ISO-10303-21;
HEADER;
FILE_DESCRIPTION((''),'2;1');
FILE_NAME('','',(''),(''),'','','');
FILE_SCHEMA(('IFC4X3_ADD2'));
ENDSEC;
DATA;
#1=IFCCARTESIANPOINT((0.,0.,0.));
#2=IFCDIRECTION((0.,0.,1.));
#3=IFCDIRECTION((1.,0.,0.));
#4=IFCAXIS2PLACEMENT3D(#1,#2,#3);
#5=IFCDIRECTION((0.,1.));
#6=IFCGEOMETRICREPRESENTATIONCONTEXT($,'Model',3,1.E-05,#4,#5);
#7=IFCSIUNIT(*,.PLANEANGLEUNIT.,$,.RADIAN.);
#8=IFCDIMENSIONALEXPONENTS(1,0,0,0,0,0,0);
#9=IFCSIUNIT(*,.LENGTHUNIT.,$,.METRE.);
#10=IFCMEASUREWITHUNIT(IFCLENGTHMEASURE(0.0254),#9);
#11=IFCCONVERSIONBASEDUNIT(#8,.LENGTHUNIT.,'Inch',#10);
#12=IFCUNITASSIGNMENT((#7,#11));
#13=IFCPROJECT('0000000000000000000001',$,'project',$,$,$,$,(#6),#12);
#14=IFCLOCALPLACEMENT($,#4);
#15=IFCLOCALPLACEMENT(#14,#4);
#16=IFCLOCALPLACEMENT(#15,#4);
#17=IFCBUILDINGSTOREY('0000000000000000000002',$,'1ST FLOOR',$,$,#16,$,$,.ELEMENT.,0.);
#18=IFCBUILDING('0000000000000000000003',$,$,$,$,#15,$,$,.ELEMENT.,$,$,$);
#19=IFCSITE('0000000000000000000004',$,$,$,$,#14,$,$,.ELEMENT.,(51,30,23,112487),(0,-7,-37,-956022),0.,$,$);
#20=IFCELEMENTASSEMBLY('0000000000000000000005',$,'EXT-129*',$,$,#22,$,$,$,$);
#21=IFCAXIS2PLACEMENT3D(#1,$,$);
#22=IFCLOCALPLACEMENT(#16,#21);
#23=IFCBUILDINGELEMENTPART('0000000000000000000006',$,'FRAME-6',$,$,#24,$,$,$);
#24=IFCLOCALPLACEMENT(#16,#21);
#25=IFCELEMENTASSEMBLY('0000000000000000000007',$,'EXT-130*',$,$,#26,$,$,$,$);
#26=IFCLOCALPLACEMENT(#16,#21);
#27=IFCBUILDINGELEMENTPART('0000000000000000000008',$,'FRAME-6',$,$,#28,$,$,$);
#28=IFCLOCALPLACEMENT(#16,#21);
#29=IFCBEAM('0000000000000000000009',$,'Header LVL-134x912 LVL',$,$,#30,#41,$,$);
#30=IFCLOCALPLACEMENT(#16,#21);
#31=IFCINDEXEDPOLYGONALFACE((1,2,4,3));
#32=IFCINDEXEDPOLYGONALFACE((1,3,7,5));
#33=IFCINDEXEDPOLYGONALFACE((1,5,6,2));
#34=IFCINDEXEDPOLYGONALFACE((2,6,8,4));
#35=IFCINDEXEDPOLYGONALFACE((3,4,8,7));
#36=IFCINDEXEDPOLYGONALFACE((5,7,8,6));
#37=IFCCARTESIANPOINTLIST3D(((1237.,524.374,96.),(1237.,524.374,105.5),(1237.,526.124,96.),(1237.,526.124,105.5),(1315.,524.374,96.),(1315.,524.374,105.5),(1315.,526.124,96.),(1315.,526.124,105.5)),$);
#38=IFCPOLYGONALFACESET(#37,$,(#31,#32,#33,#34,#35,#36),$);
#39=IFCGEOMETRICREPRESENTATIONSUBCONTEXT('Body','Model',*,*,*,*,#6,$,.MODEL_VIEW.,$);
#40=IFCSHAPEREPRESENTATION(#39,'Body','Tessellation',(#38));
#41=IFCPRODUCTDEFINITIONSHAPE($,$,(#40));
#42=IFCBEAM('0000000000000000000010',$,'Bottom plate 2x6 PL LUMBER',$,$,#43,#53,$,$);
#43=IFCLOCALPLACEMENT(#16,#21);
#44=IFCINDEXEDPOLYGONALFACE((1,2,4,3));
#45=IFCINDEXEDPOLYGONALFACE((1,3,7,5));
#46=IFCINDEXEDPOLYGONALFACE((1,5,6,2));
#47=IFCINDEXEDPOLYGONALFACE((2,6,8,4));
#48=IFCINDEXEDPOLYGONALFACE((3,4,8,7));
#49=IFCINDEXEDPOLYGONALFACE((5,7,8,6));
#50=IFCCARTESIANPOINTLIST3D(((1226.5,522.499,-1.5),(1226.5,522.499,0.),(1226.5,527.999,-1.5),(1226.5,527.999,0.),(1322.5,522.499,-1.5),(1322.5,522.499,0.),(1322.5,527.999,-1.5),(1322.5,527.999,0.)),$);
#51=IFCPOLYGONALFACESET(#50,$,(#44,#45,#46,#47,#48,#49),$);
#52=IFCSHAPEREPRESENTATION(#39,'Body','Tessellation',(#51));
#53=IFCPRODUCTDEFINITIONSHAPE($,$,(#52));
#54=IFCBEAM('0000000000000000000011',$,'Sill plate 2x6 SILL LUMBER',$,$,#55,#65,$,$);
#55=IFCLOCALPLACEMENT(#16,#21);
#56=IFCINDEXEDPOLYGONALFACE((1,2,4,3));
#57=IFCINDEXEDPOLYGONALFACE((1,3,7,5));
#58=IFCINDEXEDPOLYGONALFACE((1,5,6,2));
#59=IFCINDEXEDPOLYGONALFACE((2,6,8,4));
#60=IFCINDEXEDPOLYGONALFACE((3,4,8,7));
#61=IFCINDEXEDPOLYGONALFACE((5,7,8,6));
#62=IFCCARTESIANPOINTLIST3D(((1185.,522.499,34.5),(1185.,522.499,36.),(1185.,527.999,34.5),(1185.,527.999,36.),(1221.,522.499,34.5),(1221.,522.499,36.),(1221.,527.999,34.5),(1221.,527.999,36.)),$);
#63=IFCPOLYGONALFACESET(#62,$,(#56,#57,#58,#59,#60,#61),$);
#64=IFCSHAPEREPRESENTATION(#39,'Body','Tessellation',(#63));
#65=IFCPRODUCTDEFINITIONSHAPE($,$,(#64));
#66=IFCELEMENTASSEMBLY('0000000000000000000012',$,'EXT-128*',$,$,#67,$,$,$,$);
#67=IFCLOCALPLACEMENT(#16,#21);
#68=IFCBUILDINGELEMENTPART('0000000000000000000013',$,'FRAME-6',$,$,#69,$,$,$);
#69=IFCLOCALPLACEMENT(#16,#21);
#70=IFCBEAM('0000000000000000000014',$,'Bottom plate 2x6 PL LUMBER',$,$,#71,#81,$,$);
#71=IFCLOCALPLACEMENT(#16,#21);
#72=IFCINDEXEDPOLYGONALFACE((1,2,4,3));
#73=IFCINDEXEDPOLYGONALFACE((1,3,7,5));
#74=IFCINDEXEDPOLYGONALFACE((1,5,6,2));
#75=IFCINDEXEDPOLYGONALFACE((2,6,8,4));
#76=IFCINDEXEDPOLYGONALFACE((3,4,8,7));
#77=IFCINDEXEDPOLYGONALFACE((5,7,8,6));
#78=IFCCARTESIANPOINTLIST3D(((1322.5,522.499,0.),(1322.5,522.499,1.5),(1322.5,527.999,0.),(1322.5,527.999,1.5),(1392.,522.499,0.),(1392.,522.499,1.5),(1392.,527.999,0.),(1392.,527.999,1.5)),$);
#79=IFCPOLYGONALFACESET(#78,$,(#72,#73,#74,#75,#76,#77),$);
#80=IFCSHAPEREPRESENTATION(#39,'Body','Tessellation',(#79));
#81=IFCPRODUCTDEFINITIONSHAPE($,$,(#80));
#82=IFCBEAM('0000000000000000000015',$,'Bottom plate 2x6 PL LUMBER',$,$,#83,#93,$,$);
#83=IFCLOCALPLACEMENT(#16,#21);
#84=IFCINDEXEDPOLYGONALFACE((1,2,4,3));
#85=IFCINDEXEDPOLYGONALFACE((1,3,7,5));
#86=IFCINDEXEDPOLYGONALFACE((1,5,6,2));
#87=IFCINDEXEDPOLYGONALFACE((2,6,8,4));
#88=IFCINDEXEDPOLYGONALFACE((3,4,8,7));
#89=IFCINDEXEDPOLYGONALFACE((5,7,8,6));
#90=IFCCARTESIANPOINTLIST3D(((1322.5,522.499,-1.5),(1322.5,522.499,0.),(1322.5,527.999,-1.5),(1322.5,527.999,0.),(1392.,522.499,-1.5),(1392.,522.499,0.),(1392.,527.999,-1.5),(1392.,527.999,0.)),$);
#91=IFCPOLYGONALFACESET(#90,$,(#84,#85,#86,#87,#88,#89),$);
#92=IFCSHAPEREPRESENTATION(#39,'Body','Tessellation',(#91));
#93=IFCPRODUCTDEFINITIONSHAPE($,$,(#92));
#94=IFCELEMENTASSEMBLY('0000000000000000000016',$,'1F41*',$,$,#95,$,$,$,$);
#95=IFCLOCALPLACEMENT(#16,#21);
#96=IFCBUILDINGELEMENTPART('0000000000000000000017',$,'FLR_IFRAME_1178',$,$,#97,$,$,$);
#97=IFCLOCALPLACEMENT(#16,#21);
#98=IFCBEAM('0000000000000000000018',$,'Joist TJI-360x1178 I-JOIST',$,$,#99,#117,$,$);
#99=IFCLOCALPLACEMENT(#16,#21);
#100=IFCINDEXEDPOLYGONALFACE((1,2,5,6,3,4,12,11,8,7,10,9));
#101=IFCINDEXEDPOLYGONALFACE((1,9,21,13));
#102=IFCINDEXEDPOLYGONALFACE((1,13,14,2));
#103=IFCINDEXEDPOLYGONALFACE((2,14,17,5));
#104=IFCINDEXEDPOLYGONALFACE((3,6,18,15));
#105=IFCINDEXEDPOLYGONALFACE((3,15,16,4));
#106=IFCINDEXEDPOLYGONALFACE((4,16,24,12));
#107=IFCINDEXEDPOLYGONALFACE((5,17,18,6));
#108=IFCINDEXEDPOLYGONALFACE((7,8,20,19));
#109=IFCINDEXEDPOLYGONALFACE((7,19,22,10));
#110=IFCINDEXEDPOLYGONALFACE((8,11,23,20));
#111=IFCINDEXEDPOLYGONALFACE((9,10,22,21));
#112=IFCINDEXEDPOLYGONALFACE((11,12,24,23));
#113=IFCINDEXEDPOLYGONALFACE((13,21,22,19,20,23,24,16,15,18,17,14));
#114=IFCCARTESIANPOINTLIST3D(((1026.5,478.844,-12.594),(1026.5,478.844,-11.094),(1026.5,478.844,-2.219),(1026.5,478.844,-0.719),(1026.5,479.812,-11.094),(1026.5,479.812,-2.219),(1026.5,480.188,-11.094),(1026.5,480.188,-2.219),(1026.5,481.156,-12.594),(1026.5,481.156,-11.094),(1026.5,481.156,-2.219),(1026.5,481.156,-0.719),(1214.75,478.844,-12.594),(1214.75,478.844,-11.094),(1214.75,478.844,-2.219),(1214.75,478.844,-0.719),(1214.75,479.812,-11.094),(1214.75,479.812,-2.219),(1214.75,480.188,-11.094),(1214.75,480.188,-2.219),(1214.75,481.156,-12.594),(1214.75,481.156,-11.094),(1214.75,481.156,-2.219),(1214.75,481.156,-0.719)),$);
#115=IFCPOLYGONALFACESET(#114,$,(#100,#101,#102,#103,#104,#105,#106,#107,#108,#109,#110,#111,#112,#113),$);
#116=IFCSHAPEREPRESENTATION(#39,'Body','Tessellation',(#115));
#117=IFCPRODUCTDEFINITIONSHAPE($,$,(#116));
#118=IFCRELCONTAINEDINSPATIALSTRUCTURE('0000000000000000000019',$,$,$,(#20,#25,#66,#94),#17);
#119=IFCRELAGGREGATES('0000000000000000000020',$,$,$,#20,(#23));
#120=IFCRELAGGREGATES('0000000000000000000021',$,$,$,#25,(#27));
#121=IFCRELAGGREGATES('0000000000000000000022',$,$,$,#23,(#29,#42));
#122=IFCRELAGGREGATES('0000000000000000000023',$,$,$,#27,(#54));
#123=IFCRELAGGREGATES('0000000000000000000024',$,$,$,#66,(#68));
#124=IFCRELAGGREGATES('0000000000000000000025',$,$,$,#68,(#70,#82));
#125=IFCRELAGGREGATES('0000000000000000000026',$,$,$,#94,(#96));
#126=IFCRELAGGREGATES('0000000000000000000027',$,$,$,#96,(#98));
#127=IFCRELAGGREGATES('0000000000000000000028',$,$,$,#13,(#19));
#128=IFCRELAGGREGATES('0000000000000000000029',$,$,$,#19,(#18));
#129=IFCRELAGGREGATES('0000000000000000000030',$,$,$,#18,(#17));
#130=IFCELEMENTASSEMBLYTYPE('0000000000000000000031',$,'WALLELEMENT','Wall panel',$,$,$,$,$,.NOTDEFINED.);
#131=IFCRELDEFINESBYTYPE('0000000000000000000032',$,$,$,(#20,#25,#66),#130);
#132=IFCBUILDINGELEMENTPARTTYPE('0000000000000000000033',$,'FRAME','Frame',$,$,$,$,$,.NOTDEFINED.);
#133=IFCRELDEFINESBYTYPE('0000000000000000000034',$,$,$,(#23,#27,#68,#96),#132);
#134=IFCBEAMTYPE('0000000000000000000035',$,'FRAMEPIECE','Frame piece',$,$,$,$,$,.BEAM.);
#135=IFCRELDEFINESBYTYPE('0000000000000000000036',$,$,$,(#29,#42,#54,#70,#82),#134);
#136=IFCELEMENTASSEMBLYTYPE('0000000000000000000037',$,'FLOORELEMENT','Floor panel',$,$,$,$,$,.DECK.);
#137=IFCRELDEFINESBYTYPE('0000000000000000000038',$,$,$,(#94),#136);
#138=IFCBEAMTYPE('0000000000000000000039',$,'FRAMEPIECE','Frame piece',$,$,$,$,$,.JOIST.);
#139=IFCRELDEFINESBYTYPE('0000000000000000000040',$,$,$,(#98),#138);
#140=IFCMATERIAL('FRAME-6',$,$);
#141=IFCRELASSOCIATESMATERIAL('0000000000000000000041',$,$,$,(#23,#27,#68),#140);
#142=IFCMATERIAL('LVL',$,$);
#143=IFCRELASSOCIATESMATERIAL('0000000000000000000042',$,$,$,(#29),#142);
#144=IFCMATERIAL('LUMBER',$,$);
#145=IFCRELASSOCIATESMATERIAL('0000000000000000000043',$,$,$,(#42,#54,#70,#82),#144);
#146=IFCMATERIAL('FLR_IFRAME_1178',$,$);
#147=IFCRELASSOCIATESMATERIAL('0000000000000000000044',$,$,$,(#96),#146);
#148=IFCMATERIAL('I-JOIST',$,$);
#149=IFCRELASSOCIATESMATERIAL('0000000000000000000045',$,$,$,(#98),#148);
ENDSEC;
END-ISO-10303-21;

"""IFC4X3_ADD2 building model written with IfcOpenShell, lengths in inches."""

from ifc_helpers import new_model, entity, si_unit, converted_unit, direction, frame, origin_with_axes, origin_2d_with_axis, place, context, subcontext, project, spatial, rectangle, i_section, extrude, material, type_object, element, aggregate, save


model = new_model("IFC4X3_ADD2")

# Units and contexts
model_context = context("Model", 3, precision=1e-05, world=origin_with_axes(), true_north=direction((0.0, 1.0)))
body_context = subcontext(model_context, "Body", "Model", "MODEL_VIEW")
ifc_project = project(units=[si_unit("PLANEANGLEUNIT", "RADIAN"), converted_unit("LENGTHUNIT", "Inch", entity("IfcLengthMeasure", 0.0254), si_unit("LENGTHUNIT", "METRE"), dimensions=[1, 0, 0, 0, 0, 0, 0])], contexts=[model_context])

# Site, building, storey
site_placement = place(None, origin_with_axes())
site = spatial("IfcSite", under=ifc_project, at=site_placement, CompositionType="ELEMENT", RefLatitude=(51, 30, 23, 112487), RefLongitude=(0, -7, -37, -956022), RefElevation=0.0)
building_placement = place(site_placement, origin_with_axes())
building = spatial("IfcBuilding", under=site, at=building_placement, CompositionType="ELEMENT")
storey_placement = place(building_placement, origin_with_axes())
storey = spatial("IfcBuildingStorey", under=building, at=storey_placement, Name="1ST FLOOR", CompositionType="ELEMENT", Elevation=0.0)

# Element assemblies, building element parts
element_assembly_type_1 = type_object("IfcElementAssemblyType", Name="WALLELEMENT", Description="Wall panel", PredefinedType="NOTDEFINED")
assembly_1_placement = place(storey_placement, origin_with_axes())
assembly_1 = element("IfcElementAssembly", 1, at=assembly_1_placement, inside=storey, type_object=element_assembly_type_1, Name="EXT-129*")
ifc_material_1 = material(Name="FRAME-6")
building_element_part_type = type_object("IfcBuildingElementPartType", Name="FRAME", Description="Frame", PredefinedType="NOTDEFINED")
building_element_part_1_placement = place(storey_placement, origin_with_axes())
building_element_part_1 = element("IfcBuildingElementPart", 2, at=building_element_part_1_placement, type_object=building_element_part_type, material=ifc_material_1, Name="FRAME-6")
aggregate(assembly_1, [building_element_part_1])
ifc_material_2 = material(Name="LUMBER")
assembly_2_placement = place(storey_placement, origin_with_axes())
assembly_2 = element("IfcElementAssembly", 3, at=assembly_2_placement, inside=storey, type_object=element_assembly_type_1, Name="EXT-130*")
building_element_part_2_placement = place(storey_placement, origin_with_axes())
building_element_part_2 = element("IfcBuildingElementPart", 4, at=building_element_part_2_placement, type_object=building_element_part_type, material=ifc_material_1, Name="FRAME-6")
aggregate(assembly_2, [building_element_part_2])

# Shared definitions
element_assembly_type_2 = type_object("IfcElementAssemblyType", Name="FLOORELEMENT", Description="Floor panel", PredefinedType="DECK")
ifc_material_3 = material(Name="FLR_IFRAME_1178")
beam_type_1 = type_object("IfcBeamType", Name="FRAMEPIECE", Description="Frame piece", PredefinedType="BEAM")

# Beams
ifc_material_4 = material(Name="LVL")
beam_1_placement = place(storey_placement, frame((1237.0, 525.249, 100.75), z_axis=(1.0, 0.0, 0.0), x_axis=(0.0, 1.0, 0.0)))
beam_1 = element("IfcBeam", 5, at=beam_1_placement, type_object=beam_type_1, material=ifc_material_4, Name="Header LVL-134x912 LVL", context=body_context, shape_type="SweptSolid", body=[
    extrude(rectangle(XDim=1.75, YDim=9.5, at=origin_2d_with_axis()), origin_with_axes(), (0.0, 0.0, 1.0), 78.0),
])
beam_2_placement = place(storey_placement, frame((1226.5, 525.249, -0.75), z_axis=(1.0, 0.0, 0.0), x_axis=(0.0, 0.0, 1.0)))
beam_2 = element("IfcBeam", 6, at=beam_2_placement, type_object=beam_type_1, material=ifc_material_2, Name="Bottom plate 2x6 PL LUMBER", context=body_context, shape_type="SweptSolid", body=[
    extrude(rectangle(XDim=1.5, YDim=5.5, at=origin_2d_with_axis()), origin_with_axes(), (0.0, 0.0, 1.0), 96.0),
])
aggregate(building_element_part_1, [beam_1, beam_2])
beam_3_placement = place(storey_placement, frame((1221.0, 525.249, 35.25), z_axis=(-1.0, 0.0, 0.0), x_axis=(0.0, 0.0, -1.0)))
beam_3 = element("IfcBeam", 7, at=beam_3_placement, type_object=beam_type_1, material=ifc_material_2, Name="Sill plate 2x6 SILL LUMBER", context=body_context, shape_type="SweptSolid", body=[
    extrude(rectangle(XDim=1.5, YDim=5.5, at=origin_2d_with_axis()), origin_with_axes(), (0.0, 0.0, 1.0), 36.0),
])
aggregate(building_element_part_2, [beam_3])

# Element assembly, building element part, beams
assembly_3_placement = place(storey_placement, origin_with_axes())
assembly_3 = element("IfcElementAssembly", 8, at=assembly_3_placement, inside=storey, type_object=element_assembly_type_1, Name="EXT-128*")
building_element_part_3_placement = place(storey_placement, origin_with_axes())
building_element_part_3 = element("IfcBuildingElementPart", 9, at=building_element_part_3_placement, type_object=building_element_part_type, material=ifc_material_1, Name="FRAME-6")
aggregate(assembly_3, [building_element_part_3])
beam_4_placement = place(storey_placement, frame((1322.5, 525.249, 0.75), z_axis=(1.0, 0.0, 0.0), x_axis=(0.0, 0.0, 1.0)))
beam_4 = element("IfcBeam", 10, at=beam_4_placement, type_object=beam_type_1, material=ifc_material_2, Name="Bottom plate 2x6 PL LUMBER", context=body_context, shape_type="SweptSolid", body=[
    extrude(rectangle(XDim=1.5, YDim=5.5, at=origin_2d_with_axis()), origin_with_axes(), (0.0, 0.0, 1.0), 69.5),
])
beam_5_placement = place(storey_placement, frame((1322.5, 525.249, -0.75), z_axis=(1.0, 0.0, 0.0), x_axis=(0.0, 0.0, 1.0)))
beam_5 = element("IfcBeam", 11, at=beam_5_placement, type_object=beam_type_1, material=ifc_material_2, Name="Bottom plate 2x6 PL LUMBER", context=body_context, shape_type="SweptSolid", body=[
    extrude(rectangle(XDim=1.5, YDim=5.5, at=origin_2d_with_axis()), origin_with_axes(), (0.0, 0.0, 1.0), 69.5),
])
aggregate(building_element_part_3, [beam_4, beam_5])

# Element assembly, building element part, beam
assembly_4_placement = place(storey_placement, origin_with_axes())
assembly_4 = element("IfcElementAssembly", 12, at=assembly_4_placement, inside=storey, type_object=element_assembly_type_2, Name="1F41*")
building_element_part_4_placement = place(storey_placement, origin_with_axes())
building_element_part_4 = element("IfcBuildingElementPart", 13, at=building_element_part_4_placement, type_object=building_element_part_type, material=ifc_material_3, Name="FLR_IFRAME_1178")
aggregate(assembly_4, [building_element_part_4])
ifc_material_5 = material(Name="I-JOIST")
beam_type_2 = type_object("IfcBeamType", Name="FRAMEPIECE", Description="Frame piece", PredefinedType="JOIST")
beam_6_placement = place(storey_placement, frame((1214.75, 480.0, -6.656), z_axis=(-1.0, 0.0, 0.0), x_axis=(0.0, -1.0, 0.0)))
beam_6 = element("IfcBeam", 14, at=beam_6_placement, type_object=beam_type_2, material=ifc_material_5, Name="Joist TJI-360x1178 I-JOIST", context=body_context, shape_type="SweptSolid", body=[
    extrude(i_section(OverallWidth=2.313, OverallDepth=11.875, WebThickness=0.375, FlangeThickness=1.5, at=origin_2d_with_axis()), origin_with_axes(), (0.0, 0.0, 1.0), 188.25),
])
aggregate(building_element_part_4, [beam_6])

save(model, "model.ifc")
